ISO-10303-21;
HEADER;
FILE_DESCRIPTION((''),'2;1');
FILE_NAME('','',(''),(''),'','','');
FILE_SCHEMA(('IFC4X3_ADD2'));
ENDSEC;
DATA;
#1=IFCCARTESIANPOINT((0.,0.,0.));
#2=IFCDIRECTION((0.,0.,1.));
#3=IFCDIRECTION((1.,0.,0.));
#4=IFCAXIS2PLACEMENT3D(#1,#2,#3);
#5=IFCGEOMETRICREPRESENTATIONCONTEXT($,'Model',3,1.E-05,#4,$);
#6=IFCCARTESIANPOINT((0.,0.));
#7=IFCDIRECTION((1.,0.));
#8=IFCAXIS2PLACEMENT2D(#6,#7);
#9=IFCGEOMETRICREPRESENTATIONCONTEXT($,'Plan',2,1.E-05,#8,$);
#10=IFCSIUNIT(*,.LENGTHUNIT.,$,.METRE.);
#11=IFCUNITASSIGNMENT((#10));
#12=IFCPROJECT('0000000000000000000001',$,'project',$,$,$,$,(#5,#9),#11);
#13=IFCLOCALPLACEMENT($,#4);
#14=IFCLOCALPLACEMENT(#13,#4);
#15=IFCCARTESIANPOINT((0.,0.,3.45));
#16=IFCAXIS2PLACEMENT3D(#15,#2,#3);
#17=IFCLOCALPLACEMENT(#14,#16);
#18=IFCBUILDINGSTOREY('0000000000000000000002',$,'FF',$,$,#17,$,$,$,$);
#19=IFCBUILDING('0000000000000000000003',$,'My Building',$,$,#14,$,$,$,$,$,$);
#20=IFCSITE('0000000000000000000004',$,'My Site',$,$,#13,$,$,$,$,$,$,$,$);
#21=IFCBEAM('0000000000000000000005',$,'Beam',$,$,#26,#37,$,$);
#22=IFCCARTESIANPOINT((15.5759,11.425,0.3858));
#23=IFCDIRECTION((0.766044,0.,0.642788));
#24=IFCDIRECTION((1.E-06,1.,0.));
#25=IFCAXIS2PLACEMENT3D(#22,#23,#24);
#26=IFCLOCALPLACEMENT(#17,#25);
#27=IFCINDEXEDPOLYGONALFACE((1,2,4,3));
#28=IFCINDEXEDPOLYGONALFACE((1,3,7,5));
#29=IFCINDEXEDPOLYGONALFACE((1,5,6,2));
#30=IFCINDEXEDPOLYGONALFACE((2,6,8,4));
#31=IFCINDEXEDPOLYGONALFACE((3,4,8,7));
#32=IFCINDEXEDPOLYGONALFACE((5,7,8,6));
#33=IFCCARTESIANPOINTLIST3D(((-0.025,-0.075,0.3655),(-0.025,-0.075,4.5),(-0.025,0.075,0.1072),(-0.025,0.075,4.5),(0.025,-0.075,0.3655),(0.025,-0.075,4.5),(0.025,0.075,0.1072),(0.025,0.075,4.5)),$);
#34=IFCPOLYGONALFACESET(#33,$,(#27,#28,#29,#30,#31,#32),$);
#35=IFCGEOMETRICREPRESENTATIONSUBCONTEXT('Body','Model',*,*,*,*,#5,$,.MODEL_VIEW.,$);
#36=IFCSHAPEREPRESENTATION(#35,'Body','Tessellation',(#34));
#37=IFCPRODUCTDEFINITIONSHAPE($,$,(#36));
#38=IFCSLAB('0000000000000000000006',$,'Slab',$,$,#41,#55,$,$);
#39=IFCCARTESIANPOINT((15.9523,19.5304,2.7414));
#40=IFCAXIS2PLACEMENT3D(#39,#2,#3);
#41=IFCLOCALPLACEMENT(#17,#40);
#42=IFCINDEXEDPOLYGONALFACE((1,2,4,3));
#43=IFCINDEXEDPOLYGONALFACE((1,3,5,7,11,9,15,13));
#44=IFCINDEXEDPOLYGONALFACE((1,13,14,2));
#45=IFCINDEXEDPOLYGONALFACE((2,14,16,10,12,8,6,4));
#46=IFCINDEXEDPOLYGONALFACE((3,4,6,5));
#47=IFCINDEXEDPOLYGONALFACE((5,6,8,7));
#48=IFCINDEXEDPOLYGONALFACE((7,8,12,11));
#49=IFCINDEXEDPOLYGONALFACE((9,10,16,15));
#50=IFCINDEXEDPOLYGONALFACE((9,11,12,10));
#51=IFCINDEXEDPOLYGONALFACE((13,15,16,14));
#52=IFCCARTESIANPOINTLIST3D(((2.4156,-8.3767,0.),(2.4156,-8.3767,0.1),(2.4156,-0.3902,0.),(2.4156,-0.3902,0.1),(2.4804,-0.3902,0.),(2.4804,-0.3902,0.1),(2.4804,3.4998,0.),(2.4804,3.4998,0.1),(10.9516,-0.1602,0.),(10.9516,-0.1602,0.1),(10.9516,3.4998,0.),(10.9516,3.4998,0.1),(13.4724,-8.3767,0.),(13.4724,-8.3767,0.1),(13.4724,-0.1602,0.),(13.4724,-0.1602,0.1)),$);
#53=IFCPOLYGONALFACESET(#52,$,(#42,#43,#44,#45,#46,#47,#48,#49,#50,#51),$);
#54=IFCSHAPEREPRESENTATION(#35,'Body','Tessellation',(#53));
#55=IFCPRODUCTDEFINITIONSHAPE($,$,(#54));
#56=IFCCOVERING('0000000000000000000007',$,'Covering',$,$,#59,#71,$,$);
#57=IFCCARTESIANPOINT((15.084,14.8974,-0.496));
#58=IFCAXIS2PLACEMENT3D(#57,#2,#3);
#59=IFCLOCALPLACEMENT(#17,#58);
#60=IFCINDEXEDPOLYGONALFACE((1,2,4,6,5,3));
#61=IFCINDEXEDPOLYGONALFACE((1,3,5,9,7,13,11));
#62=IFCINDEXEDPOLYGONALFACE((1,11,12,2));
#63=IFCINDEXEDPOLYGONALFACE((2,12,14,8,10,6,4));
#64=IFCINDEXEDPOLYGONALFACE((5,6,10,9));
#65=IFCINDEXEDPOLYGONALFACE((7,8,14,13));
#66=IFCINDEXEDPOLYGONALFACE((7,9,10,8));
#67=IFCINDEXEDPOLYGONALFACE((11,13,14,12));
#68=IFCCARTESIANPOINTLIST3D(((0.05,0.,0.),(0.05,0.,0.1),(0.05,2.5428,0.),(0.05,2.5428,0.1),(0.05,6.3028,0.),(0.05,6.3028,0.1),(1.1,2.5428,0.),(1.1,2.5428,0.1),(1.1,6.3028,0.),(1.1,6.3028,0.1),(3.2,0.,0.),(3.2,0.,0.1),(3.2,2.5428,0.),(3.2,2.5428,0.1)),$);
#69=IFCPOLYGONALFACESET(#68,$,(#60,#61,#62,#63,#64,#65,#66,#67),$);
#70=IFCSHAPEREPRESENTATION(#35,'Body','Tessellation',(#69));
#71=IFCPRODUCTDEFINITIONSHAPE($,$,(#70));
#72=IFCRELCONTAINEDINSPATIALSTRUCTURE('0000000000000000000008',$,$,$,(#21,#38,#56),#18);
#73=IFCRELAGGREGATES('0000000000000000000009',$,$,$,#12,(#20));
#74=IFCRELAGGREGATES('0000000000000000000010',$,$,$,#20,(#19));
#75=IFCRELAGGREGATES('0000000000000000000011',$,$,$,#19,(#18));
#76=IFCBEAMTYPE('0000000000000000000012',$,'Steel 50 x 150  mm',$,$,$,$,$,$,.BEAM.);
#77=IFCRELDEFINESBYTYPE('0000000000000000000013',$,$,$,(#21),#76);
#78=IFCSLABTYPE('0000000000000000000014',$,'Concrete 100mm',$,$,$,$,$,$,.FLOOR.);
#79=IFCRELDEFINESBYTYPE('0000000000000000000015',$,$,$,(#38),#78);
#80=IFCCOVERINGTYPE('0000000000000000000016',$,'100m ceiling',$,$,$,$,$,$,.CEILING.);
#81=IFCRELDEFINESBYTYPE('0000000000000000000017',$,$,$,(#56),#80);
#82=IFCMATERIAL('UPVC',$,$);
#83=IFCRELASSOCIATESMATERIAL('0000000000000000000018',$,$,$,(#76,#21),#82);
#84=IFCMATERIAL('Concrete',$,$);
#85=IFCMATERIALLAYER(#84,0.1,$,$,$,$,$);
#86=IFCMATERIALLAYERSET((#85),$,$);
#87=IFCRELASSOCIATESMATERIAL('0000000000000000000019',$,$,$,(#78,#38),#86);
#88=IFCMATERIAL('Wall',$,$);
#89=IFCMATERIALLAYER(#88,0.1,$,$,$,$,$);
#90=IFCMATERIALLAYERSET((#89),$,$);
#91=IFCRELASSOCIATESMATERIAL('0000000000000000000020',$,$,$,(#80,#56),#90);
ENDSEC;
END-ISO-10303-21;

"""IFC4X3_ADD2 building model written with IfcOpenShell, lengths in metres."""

from ifc_helpers import new_model, si_unit, frame, origin_with_axes, origin_2d_with_axis, place, context, subcontext, project, spatial, line, indexed_curve, rectangle, outline, extrude, clip, halfspace, material, layer, layer_set, layer_usage, material_profile, profile_set, profile_usage, type_object, element, save


model = new_model("IFC4X3_ADD2")

# Units and contexts
model_context = context("Model", 3, precision=1e-05, world=origin_with_axes())
plan_context = context("Plan", 2, precision=1e-05, world=origin_2d_with_axis())
body_context_1 = subcontext(model_context, "Body", "Model", "MODEL_VIEW")
ifc_project = project(units=[si_unit("LENGTHUNIT", "METRE")], contexts=[model_context, plan_context])

# Site, building, storey
site_placement = place(None, origin_with_axes())
site = spatial("IfcSite", under=ifc_project, at=site_placement, Name="My Site")
building_placement = place(site_placement, origin_with_axes())
building = spatial("IfcBuilding", under=site, at=building_placement, Name="My Building")
storey_placement = place(building_placement, frame((0.0, 0.0, 3.45), z_axis=(0.0, 0.0, 1.0), x_axis=(1.0, 0.0, 0.0)))
storey = spatial("IfcBuildingStorey", under=building, at=storey_placement, Name="FF")

# Beam
ifc_material_1 = material(Name="UPVC")
ifc_material_profile = material_profile(ifc_material_1, rectangle(XDim=0.05, YDim=0.15))
ifc_profile_set = profile_set([ifc_material_profile])
beam_type = type_object("IfcBeamType", Name="Steel 50 x 150  mm", PredefinedType="BEAM", material=ifc_profile_set)
ifc_profile_usage_1 = profile_usage(ifc_profile_set)
beam_1_placement = place(storey_placement, frame((15.5759, 11.425, 0.3858), z_axis=(0.766044, 0.0, 0.642788), x_axis=(0.000001, 1.0, 0.0)))
element("IfcBeam", 1, at=beam_1_placement, inside=storey, type_object=beam_type, material=ifc_profile_usage_1, Name="Beam", context=body_context_1, shape_type="Clipping", body=[
    clip(extrude(rectangle(XDim=0.05, YDim=0.15), origin_with_axes(), (0.0, 0.0, 1.0), 4.5), halfspace(frame((-11.425, 0.075, 0.1072), z_axis=(0.0, -0.864748, -0.502207), x_axis=(-1.0, 0.0, 0.0)), False)),
])

# Slab
ifc_material_2 = material(Name="Concrete")
ifc_layer_1 = layer(ifc_material_2, 0.1)
ifc_layer_set_1 = layer_set([ifc_layer_1])
ifc_layer_usage_1 = layer_usage(ifc_layer_set_1, "AXIS3", "POSITIVE", 0.0)
slab_type = type_object("IfcSlabType", Name="Concrete 100mm", PredefinedType="FLOOR", material=ifc_layer_set_1)
slab_placement = place(storey_placement, frame((15.9523, 19.5304, 2.7414), z_axis=(0.0, 0.0, 1.0), x_axis=(1.0, 0.0, 0.0)))
element("IfcSlab", 2, at=slab_placement, inside=storey, type_object=slab_type, material=ifc_layer_usage_1, Name="Slab", context=body_context_1, shape_type="SweptSolid", body=[
    extrude(outline(indexed_curve([(2.4804, 3.4998), (2.4804, -0.3902), (2.4156, -0.3902), (2.4156, -8.3767), (13.4724, -8.3767), (13.4724, -0.1602), (10.9516, -0.1602), (10.9516, 3.4998)], segments=[line(3, 2), line(2, 1), line(1, 8), line(8, 7), line(7, 6), line(6, 5), line(5, 4), line(4, 3)], self_intersect=False)), None, (0.0, 0.0, 1.0), 0.1),
])

# Shared definitions
ifc_material_3 = material(Name="Wall")

# Covering
ifc_layer_2 = layer(ifc_material_3, 0.1)
ifc_layer_set_2 = layer_set([ifc_layer_2])
ifc_layer_usage_2 = layer_usage(ifc_layer_set_2, "AXIS3", "POSITIVE", 0.0)
covering_type = type_object("IfcCoveringType", Name="100m ceiling", PredefinedType="CEILING", material=ifc_layer_set_2)
covering_placement = place(storey_placement, frame((15.084, 14.8974, -0.496), z_axis=(0.0, 0.0, 1.0), x_axis=(1.0, 0.0, 0.0)))
element("IfcCovering", 3, at=covering_placement, inside=storey, type_object=covering_type, material=ifc_layer_usage_2, Name="Covering", context=body_context_1, shape_type="SweptSolid", body=[
    extrude(outline(indexed_curve([(0.05, 6.3028), (0.05, 2.5428), (0.05, 0.0), (3.2, 0.0), (3.2, 2.5428), (1.1, 2.5428), (1.1, 6.3028)], segments=[line(4, 3), line(3, 2), line(2, 1), line(1, 7), line(7, 6), line(6, 5), line(5, 4)], self_intersect=False)), None, (0.0, 0.0, 1.0), 0.1),
])

save(model, "model.ifc")
